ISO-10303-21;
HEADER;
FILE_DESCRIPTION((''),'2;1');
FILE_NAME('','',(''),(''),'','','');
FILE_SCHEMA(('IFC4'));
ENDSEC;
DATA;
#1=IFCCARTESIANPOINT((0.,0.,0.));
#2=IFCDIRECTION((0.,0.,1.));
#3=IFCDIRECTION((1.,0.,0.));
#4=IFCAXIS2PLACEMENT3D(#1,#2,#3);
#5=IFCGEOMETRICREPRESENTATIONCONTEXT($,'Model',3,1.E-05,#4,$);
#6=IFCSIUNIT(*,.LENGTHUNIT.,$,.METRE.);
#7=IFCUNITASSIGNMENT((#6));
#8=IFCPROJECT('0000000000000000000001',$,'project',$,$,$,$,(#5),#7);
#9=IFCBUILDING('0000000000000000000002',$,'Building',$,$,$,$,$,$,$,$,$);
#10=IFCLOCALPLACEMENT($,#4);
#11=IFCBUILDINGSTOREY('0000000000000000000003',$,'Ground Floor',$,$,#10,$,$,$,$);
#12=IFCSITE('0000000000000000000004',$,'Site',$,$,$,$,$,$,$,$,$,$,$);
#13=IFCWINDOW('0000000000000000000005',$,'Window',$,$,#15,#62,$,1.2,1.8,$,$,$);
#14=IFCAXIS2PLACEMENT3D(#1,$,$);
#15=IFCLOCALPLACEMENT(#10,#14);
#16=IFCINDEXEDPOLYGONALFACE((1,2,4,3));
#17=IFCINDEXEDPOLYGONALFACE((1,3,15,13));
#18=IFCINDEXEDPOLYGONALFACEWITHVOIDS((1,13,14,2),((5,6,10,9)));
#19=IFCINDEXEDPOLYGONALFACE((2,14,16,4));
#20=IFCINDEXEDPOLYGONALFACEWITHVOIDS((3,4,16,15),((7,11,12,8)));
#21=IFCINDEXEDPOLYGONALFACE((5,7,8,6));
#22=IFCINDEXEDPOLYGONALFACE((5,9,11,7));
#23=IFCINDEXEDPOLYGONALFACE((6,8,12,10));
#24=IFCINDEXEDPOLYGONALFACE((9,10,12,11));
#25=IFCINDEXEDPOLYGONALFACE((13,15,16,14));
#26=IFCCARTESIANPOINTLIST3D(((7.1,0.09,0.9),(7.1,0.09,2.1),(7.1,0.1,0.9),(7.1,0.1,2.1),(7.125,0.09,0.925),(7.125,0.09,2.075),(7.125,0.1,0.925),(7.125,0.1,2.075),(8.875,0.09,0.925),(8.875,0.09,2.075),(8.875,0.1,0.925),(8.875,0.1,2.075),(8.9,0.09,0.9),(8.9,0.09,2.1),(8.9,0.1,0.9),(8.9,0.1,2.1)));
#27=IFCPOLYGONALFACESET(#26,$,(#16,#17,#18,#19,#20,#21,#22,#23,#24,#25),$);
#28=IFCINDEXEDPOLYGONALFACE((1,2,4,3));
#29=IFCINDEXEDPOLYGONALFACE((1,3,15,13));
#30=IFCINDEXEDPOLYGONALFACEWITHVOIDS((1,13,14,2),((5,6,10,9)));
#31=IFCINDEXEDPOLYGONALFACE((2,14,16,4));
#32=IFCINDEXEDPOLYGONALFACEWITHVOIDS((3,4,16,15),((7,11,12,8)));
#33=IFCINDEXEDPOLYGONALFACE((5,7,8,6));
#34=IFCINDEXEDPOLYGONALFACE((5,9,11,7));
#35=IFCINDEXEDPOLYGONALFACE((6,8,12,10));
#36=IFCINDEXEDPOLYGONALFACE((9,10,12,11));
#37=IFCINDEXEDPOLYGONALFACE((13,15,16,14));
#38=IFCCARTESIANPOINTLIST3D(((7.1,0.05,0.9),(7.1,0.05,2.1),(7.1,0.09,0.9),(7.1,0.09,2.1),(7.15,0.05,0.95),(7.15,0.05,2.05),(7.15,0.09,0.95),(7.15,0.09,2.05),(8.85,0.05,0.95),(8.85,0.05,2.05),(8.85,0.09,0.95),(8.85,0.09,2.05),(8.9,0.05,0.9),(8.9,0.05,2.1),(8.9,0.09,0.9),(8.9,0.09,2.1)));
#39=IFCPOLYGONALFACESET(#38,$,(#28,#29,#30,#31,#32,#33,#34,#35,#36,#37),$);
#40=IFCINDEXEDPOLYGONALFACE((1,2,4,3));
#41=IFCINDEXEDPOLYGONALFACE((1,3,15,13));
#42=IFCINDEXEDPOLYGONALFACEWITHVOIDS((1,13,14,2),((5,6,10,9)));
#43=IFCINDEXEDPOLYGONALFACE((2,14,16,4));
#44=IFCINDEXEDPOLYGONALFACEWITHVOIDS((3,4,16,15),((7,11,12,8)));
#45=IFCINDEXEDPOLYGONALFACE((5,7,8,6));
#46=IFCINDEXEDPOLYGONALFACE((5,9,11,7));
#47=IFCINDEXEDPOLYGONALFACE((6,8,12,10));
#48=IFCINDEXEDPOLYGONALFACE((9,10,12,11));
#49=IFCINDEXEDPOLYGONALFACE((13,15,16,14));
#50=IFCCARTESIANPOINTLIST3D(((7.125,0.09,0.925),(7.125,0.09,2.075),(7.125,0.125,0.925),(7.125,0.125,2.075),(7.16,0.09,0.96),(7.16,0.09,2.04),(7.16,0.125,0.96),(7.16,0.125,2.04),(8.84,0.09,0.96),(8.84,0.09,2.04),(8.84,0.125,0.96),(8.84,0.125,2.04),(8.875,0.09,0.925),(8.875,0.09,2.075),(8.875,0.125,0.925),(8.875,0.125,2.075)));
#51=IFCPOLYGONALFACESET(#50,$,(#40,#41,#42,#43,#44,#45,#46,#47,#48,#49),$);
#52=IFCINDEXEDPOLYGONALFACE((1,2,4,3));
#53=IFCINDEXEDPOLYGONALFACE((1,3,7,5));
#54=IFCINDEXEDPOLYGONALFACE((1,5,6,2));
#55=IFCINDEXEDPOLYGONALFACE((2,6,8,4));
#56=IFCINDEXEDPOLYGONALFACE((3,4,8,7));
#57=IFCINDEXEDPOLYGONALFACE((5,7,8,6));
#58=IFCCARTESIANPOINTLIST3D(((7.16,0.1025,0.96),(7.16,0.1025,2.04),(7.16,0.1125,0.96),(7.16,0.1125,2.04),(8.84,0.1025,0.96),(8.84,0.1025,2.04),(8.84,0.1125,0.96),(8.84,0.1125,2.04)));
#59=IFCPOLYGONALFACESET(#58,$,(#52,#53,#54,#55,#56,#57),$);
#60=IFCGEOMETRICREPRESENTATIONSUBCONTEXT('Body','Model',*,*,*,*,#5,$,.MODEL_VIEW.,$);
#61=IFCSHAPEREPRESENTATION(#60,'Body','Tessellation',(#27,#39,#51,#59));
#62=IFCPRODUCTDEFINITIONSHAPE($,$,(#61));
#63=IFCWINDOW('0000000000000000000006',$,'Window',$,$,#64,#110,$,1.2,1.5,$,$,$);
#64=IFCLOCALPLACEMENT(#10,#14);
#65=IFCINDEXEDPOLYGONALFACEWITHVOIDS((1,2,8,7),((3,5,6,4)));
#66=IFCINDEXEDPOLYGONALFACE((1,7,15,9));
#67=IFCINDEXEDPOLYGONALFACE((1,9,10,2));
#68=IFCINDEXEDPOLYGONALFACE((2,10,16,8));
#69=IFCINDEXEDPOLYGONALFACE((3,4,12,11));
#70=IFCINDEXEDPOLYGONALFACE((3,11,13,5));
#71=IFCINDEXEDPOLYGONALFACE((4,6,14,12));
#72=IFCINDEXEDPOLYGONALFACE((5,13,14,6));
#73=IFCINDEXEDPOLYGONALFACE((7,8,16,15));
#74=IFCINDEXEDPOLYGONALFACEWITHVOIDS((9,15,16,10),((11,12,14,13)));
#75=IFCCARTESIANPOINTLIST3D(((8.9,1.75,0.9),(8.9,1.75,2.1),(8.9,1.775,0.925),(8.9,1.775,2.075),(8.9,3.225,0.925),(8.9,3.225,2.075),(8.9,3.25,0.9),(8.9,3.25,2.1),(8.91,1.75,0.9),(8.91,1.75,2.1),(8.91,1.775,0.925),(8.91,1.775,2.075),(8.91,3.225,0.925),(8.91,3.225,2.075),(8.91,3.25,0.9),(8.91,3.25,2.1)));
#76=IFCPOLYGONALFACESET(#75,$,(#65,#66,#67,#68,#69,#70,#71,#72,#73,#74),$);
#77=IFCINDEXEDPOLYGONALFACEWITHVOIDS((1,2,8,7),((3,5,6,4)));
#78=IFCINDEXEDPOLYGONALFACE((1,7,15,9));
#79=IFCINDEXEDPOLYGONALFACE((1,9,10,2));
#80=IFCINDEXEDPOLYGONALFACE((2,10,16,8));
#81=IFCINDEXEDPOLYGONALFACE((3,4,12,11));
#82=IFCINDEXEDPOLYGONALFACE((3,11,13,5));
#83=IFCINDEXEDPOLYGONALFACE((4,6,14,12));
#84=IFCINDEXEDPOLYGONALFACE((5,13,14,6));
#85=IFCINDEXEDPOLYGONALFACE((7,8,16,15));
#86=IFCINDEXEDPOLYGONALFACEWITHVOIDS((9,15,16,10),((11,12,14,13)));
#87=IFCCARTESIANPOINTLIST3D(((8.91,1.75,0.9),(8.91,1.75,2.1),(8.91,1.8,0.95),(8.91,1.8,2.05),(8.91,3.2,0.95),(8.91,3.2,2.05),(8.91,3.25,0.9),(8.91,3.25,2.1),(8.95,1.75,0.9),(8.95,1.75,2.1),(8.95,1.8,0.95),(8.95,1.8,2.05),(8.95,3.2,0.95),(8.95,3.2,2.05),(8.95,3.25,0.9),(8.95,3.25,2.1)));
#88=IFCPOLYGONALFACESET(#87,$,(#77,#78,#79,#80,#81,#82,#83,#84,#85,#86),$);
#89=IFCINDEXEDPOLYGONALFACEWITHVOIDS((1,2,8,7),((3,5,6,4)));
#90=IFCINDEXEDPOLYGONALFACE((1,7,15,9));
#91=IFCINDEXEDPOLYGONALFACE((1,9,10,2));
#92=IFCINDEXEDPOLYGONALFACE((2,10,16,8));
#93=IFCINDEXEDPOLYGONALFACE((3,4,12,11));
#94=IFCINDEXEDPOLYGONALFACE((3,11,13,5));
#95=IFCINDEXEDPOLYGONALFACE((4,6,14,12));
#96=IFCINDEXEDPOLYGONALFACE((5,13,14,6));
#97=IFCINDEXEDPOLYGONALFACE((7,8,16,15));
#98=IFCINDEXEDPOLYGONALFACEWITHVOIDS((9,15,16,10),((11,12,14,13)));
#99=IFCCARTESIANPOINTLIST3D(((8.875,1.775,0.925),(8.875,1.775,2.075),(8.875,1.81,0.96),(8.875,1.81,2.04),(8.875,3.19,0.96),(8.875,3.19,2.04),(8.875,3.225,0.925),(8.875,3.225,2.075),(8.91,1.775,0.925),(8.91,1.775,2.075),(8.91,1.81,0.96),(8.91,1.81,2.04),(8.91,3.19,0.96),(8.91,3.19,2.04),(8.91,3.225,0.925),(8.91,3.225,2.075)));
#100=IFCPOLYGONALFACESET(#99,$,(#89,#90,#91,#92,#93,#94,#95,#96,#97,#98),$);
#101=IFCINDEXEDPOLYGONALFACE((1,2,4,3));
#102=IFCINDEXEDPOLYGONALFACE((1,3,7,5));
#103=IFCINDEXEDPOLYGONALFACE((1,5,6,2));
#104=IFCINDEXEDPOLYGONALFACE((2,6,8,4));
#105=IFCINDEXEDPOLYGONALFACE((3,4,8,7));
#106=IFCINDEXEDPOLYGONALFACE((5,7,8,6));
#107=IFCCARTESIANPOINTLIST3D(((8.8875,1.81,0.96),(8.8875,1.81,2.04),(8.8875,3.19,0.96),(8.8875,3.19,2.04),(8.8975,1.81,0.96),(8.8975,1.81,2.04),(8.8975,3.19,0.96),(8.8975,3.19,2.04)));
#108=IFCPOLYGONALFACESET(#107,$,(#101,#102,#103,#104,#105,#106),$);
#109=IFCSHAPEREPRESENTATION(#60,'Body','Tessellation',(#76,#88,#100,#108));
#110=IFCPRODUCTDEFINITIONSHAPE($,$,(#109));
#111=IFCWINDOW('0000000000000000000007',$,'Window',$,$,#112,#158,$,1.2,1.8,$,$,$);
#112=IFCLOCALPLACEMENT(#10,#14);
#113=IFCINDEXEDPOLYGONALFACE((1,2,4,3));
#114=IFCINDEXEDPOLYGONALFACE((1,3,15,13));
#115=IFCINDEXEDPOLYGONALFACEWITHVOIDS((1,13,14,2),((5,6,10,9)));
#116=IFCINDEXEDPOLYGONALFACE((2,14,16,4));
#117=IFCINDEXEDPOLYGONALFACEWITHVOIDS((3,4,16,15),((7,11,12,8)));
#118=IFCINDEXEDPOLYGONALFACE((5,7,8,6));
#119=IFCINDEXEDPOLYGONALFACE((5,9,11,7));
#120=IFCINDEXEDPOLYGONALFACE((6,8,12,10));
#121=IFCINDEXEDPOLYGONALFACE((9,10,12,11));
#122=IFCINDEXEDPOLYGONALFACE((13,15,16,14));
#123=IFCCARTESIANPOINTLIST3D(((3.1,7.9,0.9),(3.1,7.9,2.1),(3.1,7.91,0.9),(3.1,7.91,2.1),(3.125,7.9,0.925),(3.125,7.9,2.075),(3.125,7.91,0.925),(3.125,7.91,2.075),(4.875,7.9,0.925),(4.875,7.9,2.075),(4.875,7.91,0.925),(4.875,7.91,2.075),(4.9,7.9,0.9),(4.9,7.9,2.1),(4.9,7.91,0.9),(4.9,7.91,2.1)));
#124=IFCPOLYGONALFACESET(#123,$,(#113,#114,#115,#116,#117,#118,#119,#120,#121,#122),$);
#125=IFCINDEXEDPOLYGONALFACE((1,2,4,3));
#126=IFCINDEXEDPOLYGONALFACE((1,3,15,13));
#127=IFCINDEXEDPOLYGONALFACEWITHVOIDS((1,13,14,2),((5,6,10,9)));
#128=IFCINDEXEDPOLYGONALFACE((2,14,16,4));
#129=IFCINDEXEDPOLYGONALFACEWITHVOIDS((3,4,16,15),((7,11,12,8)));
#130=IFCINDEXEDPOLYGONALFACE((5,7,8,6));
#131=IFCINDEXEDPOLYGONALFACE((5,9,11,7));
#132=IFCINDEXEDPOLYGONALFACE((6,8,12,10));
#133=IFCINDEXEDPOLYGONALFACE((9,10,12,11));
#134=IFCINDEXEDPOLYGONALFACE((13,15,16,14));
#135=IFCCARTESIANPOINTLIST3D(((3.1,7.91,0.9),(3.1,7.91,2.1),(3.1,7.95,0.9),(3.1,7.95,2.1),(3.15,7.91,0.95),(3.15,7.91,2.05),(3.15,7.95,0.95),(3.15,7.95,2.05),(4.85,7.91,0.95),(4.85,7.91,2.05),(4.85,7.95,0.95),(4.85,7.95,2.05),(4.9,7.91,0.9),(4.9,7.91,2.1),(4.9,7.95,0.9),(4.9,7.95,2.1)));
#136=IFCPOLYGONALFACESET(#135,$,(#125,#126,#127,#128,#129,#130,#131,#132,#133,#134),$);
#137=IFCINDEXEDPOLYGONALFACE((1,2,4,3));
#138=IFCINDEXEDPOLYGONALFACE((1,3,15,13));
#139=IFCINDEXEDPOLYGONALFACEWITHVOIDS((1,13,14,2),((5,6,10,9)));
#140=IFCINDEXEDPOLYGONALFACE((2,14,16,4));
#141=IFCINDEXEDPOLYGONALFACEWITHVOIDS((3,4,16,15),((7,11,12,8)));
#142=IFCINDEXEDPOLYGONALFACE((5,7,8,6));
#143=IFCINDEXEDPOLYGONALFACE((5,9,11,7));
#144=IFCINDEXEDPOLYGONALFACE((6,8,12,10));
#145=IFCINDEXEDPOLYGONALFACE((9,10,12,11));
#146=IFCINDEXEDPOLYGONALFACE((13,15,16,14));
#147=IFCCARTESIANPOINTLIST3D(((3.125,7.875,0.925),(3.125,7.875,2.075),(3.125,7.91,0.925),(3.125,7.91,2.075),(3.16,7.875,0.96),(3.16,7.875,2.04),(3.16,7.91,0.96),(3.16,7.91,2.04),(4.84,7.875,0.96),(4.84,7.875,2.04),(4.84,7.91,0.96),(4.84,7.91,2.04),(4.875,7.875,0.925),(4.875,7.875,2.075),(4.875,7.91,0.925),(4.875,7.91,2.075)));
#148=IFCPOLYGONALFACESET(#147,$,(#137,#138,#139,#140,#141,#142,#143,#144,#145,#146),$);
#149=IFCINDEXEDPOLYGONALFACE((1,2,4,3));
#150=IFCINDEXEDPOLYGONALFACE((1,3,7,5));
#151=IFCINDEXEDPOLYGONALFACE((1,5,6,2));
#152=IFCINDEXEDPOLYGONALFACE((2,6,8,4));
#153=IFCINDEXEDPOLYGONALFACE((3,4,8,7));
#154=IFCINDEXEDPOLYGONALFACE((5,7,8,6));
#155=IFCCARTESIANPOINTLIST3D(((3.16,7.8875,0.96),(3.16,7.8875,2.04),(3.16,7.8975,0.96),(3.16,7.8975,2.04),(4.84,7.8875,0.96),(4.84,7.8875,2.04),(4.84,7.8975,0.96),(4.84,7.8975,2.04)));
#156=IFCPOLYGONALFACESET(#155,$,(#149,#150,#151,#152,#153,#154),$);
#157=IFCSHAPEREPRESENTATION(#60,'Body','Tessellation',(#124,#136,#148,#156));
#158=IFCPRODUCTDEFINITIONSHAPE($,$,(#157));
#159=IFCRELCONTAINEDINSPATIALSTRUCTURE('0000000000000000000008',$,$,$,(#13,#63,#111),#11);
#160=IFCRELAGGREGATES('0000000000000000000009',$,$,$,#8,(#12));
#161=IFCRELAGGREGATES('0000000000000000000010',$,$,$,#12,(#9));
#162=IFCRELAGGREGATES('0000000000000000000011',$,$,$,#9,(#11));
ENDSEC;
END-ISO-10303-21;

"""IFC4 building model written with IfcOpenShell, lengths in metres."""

from ifc_helpers import new_model, si_unit, frame, origin_with_axes, place, context, subcontext, project, spatial, line, indexed_curve, outline, extrude, element, save


model = new_model("IFC4")

# Units and contexts
model_context = context("Model", 3, precision=1e-05, world=origin_with_axes())
body_context = subcontext(model_context, "Body", "Model", "MODEL_VIEW")
ifc_project = project(units=[si_unit("LENGTHUNIT", "METRE")], contexts=[model_context])

# Site, building, storey
site = spatial("IfcSite", under=ifc_project, Name="Site")
building = spatial("IfcBuilding", under=site, Name="Building")
storey_placement = place(None, origin_with_axes())
storey = spatial("IfcBuildingStorey", under=building, at=storey_placement, Name="Ground Floor")

# Windows
window_1_placement = place(storey_placement, frame((7.1, 0.0, 0.9), z_axis=(0.0, 0.0, 1.0), x_axis=(1.0, 0.0, 0.0)))
element("IfcWindow", 1, at=window_1_placement, inside=storey, Name="Window", OverallHeight=1.2, OverallWidth=1.8, context=body_context, shape_type="SweptSolid", body=[
    extrude(outline(indexed_curve([(0.0, 0.0), (1.8, 0.0), (1.8, 1.2), (0.0, 1.2)], segments=[line(1, 2, 3, 4, 1)]), holes=[indexed_curve([(0.025, 0.025), (1.775, 0.025), (1.775, 1.175), (0.025, 1.175)], segments=[line(1, 2, 3, 4, 1)])]), frame((0.0, 0.09, 0.0), z_axis=(0.0, -1.0, 0.0), x_axis=(1.0, 0.0, 0.0)), (0.0, 0.0, -1.0), 0.01),
    extrude(outline(indexed_curve([(0.0, 0.0), (1.8, 0.0), (1.8, 1.2), (0.0, 1.2)], segments=[line(1, 2, 3, 4, 1)]), holes=[indexed_curve([(0.05, 0.05), (1.75, 0.05), (1.75, 1.15), (0.05, 1.15)], segments=[line(1, 2, 3, 4, 1)])]), frame((0.0, 0.05, 0.0), z_axis=(0.0, -1.0, 0.0), x_axis=(1.0, 0.0, 0.0)), (0.0, 0.0, -1.0), 0.04),
    extrude(outline(indexed_curve([(0.0, 0.0), (1.75, 0.0), (1.75, 1.15), (0.0, 1.15)], segments=[line(1, 2, 3, 4, 1)]), holes=[indexed_curve([(0.035, 0.035), (1.715, 0.035), (1.715, 1.115), (0.035, 1.115)], segments=[line(1, 2, 3, 4, 1)])]), frame((0.025, 0.09, 0.025), z_axis=(0.0, -1.0, 0.0), x_axis=(1.0, 0.0, 0.0)), (0.0, 0.0, -1.0), 0.035),
    extrude(outline(indexed_curve([(0.035, 0.035), (1.715, 0.035), (1.715, 1.115), (0.035, 1.115)], segments=[line(1, 2, 3, 4, 1)])), frame((0.025, 0.1025, 0.025), z_axis=(0.0, -1.0, 0.0), x_axis=(1.0, 0.0, 0.0)), (0.0, 0.0, -1.0), 0.01),
])
window_2_placement = place(storey_placement, frame((9.0, 1.75, 0.9), z_axis=(0.0, 0.0, 1.0), x_axis=(0.0, 1.0, 0.0)))
element("IfcWindow", 2, at=window_2_placement, inside=storey, Name="Window", OverallHeight=1.2, OverallWidth=1.5, context=body_context, shape_type="SweptSolid", body=[
    extrude(outline(indexed_curve([(0.0, 0.0), (1.5, 0.0), (1.5, 1.2), (0.0, 1.2)], segments=[line(1, 2, 3, 4, 1)]), holes=[indexed_curve([(0.025, 0.025), (1.475, 0.025), (1.475, 1.175), (0.025, 1.175)], segments=[line(1, 2, 3, 4, 1)])]), frame((0.0, 0.09, 0.0), z_axis=(0.0, -1.0, 0.0), x_axis=(1.0, 0.0, 0.0)), (0.0, 0.0, -1.0), 0.01),
    extrude(outline(indexed_curve([(0.0, 0.0), (1.5, 0.0), (1.5, 1.2), (0.0, 1.2)], segments=[line(1, 2, 3, 4, 1)]), holes=[indexed_curve([(0.05, 0.05), (1.45, 0.05), (1.45, 1.15), (0.05, 1.15)], segments=[line(1, 2, 3, 4, 1)])]), frame((0.0, 0.05, 0.0), z_axis=(0.0, -1.0, 0.0), x_axis=(1.0, 0.0, 0.0)), (0.0, 0.0, -1.0), 0.04),
    extrude(outline(indexed_curve([(0.0, 0.0), (1.45, 0.0), (1.45, 1.15), (0.0, 1.15)], segments=[line(1, 2, 3, 4, 1)]), holes=[indexed_curve([(0.035, 0.035), (1.415, 0.035), (1.415, 1.115), (0.035, 1.115)], segments=[line(1, 2, 3, 4, 1)])]), frame((0.025, 0.09, 0.025), z_axis=(0.0, -1.0, 0.0), x_axis=(1.0, 0.0, 0.0)), (0.0, 0.0, -1.0), 0.035),
    extrude(outline(indexed_curve([(0.035, 0.035), (1.415, 0.035), (1.415, 1.115), (0.035, 1.115)], segments=[line(1, 2, 3, 4, 1)])), frame((0.025, 0.1025, 0.025), z_axis=(0.0, -1.0, 0.0), x_axis=(1.0, 0.0, 0.0)), (0.0, 0.0, -1.0), 0.01),
])
window_3_placement = place(storey_placement, frame((4.9, 8.0, 0.9), z_axis=(0.0, 0.0, 1.0), x_axis=(-1.0, 0.0, 0.0)))
element("IfcWindow", 3, at=window_3_placement, inside=storey, Name="Window", OverallHeight=1.2, OverallWidth=1.8, context=body_context, shape_type="SweptSolid", body=[
    extrude(outline(indexed_curve([(0.0, 0.0), (1.8, 0.0), (1.8, 1.2), (0.0, 1.2)], segments=[line(1, 2, 3, 4, 1)]), holes=[indexed_curve([(0.025, 0.025), (1.775, 0.025), (1.775, 1.175), (0.025, 1.175)], segments=[line(1, 2, 3, 4, 1)])]), frame((0.0, 0.09, 0.0), z_axis=(0.0, -1.0, 0.0), x_axis=(1.0, 0.0, 0.0)), (0.0, 0.0, -1.0), 0.01),
    extrude(outline(indexed_curve([(0.0, 0.0), (1.8, 0.0), (1.8, 1.2), (0.0, 1.2)], segments=[line(1, 2, 3, 4, 1)]), holes=[indexed_curve([(0.05, 0.05), (1.75, 0.05), (1.75, 1.15), (0.05, 1.15)], segments=[line(1, 2, 3, 4, 1)])]), frame((0.0, 0.05, 0.0), z_axis=(0.0, -1.0, 0.0), x_axis=(1.0, 0.0, 0.0)), (0.0, 0.0, -1.0), 0.04),
    extrude(outline(indexed_curve([(0.0, 0.0), (1.75, 0.0), (1.75, 1.15), (0.0, 1.15)], segments=[line(1, 2, 3, 4, 1)]), holes=[indexed_curve([(0.035, 0.035), (1.715, 0.035), (1.715, 1.115), (0.035, 1.115)], segments=[line(1, 2, 3, 4, 1)])]), frame((0.025, 0.09, 0.025), z_axis=(0.0, -1.0, 0.0), x_axis=(1.0, 0.0, 0.0)), (0.0, 0.0, -1.0), 0.035),
    extrude(outline(indexed_curve([(0.035, 0.035), (1.715, 0.035), (1.715, 1.115), (0.035, 1.115)], segments=[line(1, 2, 3, 4, 1)])), frame((0.025, 0.1025, 0.025), z_axis=(0.0, -1.0, 0.0), x_axis=(1.0, 0.0, 0.0)), (0.0, 0.0, -1.0), 0.01),
])

save(model, "model.ifc")
